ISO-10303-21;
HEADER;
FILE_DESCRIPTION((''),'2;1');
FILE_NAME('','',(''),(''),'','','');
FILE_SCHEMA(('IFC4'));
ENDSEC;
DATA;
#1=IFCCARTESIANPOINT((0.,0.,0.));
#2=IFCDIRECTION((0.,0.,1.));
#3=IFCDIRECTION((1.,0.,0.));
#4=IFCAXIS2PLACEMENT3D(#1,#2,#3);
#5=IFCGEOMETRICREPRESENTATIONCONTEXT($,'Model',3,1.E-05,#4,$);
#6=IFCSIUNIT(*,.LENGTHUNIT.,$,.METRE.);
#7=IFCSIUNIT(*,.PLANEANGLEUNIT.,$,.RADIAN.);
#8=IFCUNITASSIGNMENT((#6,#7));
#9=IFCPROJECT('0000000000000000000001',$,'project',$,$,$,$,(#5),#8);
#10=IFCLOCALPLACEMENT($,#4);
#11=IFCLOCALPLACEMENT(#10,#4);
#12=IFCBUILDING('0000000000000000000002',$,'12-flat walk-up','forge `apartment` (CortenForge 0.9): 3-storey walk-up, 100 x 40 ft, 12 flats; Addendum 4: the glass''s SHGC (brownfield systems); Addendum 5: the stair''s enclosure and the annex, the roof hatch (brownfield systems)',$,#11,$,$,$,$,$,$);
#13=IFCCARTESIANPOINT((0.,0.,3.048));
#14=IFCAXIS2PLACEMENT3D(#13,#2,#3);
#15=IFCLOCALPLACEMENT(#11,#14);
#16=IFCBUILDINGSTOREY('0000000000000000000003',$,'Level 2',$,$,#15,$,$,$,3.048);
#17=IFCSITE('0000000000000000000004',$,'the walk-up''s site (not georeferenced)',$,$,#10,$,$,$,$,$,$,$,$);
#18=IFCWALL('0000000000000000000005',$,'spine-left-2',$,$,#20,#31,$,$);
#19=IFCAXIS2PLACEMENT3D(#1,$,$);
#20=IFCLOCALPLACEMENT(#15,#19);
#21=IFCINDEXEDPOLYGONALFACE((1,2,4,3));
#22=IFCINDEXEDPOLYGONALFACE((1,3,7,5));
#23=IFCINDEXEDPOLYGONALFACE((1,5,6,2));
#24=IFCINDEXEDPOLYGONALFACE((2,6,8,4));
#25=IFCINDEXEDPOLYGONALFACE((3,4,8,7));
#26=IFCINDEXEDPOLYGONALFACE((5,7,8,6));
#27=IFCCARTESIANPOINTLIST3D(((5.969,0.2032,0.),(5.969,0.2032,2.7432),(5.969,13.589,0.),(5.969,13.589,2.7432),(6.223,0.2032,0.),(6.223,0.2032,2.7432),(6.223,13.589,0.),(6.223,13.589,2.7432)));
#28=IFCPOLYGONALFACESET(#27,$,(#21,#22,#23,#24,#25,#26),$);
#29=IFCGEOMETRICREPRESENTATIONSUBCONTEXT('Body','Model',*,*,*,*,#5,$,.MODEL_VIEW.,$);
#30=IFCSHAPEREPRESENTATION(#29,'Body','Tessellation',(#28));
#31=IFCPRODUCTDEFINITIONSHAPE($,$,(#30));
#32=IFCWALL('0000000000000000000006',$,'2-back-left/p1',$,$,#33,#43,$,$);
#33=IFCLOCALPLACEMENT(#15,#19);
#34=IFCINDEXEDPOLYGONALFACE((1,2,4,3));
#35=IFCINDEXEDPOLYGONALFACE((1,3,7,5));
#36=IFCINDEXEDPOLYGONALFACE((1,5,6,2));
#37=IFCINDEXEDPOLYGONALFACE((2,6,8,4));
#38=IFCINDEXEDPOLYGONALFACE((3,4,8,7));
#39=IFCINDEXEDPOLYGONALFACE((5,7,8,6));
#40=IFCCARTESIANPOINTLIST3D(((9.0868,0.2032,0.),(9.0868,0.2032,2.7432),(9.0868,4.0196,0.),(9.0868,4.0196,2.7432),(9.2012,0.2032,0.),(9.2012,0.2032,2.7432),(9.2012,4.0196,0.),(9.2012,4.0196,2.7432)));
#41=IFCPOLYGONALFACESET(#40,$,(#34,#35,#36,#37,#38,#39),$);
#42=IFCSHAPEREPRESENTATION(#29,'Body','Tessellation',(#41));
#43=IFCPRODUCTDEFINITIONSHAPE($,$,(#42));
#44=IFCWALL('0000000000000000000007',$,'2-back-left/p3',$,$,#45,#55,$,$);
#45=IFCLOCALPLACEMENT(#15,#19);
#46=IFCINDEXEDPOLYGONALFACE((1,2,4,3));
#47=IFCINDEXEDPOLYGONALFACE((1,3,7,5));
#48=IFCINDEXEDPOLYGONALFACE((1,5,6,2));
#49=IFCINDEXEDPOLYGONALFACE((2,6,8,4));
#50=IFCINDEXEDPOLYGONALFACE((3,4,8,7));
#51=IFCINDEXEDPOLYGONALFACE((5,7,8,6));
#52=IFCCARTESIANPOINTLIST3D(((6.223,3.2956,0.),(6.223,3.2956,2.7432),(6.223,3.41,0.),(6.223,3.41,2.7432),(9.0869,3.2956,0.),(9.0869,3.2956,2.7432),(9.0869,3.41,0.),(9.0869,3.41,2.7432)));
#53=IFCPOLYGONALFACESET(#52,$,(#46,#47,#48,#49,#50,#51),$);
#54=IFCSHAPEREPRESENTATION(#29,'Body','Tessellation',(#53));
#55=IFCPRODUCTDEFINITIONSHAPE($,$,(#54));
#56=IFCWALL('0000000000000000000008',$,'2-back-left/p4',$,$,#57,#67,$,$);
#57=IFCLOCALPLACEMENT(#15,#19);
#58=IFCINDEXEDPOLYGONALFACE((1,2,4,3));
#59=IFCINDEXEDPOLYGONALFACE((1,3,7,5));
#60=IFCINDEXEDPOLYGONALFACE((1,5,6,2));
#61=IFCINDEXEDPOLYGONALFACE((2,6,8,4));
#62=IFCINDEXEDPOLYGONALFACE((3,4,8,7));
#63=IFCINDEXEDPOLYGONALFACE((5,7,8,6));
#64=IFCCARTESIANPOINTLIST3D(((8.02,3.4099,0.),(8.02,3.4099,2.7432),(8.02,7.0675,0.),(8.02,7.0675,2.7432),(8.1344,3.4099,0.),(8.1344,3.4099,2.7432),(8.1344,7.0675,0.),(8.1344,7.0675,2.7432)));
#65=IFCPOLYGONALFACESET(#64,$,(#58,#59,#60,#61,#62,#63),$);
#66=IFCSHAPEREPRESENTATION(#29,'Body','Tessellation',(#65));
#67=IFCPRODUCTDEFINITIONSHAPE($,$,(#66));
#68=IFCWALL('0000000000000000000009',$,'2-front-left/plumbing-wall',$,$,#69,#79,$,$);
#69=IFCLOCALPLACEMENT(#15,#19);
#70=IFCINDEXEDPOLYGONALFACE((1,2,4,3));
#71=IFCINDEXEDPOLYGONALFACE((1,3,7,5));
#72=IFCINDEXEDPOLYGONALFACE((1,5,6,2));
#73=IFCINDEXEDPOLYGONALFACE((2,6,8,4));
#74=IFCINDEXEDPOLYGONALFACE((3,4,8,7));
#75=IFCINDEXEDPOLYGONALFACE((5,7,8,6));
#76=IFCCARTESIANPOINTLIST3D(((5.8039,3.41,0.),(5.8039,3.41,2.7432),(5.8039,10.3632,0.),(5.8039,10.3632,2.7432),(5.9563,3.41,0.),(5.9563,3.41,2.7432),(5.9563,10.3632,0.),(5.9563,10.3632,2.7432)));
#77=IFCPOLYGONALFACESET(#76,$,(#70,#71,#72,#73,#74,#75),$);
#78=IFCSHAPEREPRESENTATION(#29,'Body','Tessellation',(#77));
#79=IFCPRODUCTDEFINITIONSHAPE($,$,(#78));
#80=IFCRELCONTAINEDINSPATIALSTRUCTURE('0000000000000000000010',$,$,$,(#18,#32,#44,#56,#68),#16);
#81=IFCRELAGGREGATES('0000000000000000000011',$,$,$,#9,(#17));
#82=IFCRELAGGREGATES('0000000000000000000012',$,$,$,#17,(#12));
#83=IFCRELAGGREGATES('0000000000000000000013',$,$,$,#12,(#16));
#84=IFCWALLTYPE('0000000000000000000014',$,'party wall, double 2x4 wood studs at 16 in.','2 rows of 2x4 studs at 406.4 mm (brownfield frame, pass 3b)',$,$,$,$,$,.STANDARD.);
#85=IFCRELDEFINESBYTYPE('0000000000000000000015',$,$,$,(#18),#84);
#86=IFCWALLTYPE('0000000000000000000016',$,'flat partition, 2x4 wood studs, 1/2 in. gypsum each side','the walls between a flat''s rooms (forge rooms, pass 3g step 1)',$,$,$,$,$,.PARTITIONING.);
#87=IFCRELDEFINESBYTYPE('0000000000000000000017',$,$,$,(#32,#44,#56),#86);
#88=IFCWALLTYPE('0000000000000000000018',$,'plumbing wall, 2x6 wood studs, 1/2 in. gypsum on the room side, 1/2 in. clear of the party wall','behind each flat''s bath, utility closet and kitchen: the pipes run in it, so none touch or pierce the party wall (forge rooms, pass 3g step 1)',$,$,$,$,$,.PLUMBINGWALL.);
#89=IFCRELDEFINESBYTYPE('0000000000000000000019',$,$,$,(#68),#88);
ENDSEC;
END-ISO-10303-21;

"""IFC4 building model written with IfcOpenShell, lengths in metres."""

from ifc_helpers import new_model, si_unit, frame, frame_2d, origin, origin_with_axes, place, context, subcontext, project, spatial, rectangle, extrude, type_object, element, save


model = new_model("IFC4")

# Units and contexts
model_context = context("Model", 3, precision=1e-05, world=origin_with_axes())
body_context = subcontext(model_context, "Body", "Model", "MODEL_VIEW")
ifc_project = project(units=[si_unit("LENGTHUNIT", "METRE"), si_unit("PLANEANGLEUNIT", "RADIAN")], contexts=[model_context])

# Site, building, storey
site_placement = place(None, origin_with_axes())
site = spatial("IfcSite", under=ifc_project, at=site_placement, Name="the walk-up's site (not georeferenced)")
building_placement = place(site_placement, origin_with_axes())
building = spatial("IfcBuilding", under=site, at=building_placement, Name="12-flat walk-up", Description="forge `apartment` (CortenForge 0.9): 3-storey walk-up, 100 x 40 ft, 12 flats; Addendum 4: the glass's SHGC (brownfield systems); Addendum 5: the stair's enclosure and the annex, the roof hatch (brownfield systems)")
storey_placement = place(building_placement, frame((0.0, 0.0, 3.048), z_axis=(0.0, 0.0, 1.0), x_axis=(1.0, 0.0, 0.0)))
storey = spatial("IfcBuildingStorey", under=building, at=storey_placement, Name="Level 2", Elevation=3.048)

# Walls
wall_type_1 = type_object("IfcWallType", Name="party wall, double 2x4 wood studs at 16 in.", Description="2 rows of 2x4 studs at 406.4 mm (brownfield frame, pass 3b)", PredefinedType="STANDARD")
wall_1_placement = place(storey_placement, frame((5.969, 0.2032, 0.0), z_axis=(0.0, 0.0, 1.0), x_axis=(1.0, 0.0, 0.0)))
element("IfcWall", 1, at=wall_1_placement, inside=storey, type_object=wall_type_1, Name="spine-left-2", context=body_context, shape_type="SweptSolid", body=[
    extrude(rectangle(XDim=0.254, YDim=13.3858, at=frame_2d((0.127, 6.6929))), origin(), (0.0, 0.0, 1.0), 2.7432),
])
wall_type_2 = type_object("IfcWallType", Name="flat partition, 2x4 wood studs, 1/2 in. gypsum each side", Description="the walls between a flat's rooms (forge rooms, pass 3g step 1)", PredefinedType="PARTITIONING")
wall_2_placement = place(storey_placement, frame((9.0869, 0.2032, 0.0), z_axis=(0.0, 0.0, 1.0), x_axis=(1.0, 0.0, 0.0)))
element("IfcWall", 2, at=wall_2_placement, inside=storey, type_object=wall_type_2, Name="2-back-left/p1", context=body_context, shape_type="SweptSolid", body=[
    extrude(rectangle(XDim=0.1143, YDim=3.8163, at=frame_2d((0.0572, 1.9082))), origin(), (0.0, 0.0, 1.0), 2.7432),
])
wall_3_placement = place(storey_placement, frame((6.223, 3.2957, 0.0), z_axis=(0.0, 0.0, 1.0), x_axis=(1.0, 0.0, 0.0)))
element("IfcWall", 3, at=wall_3_placement, inside=storey, type_object=wall_type_2, Name="2-back-left/p3", context=body_context, shape_type="SweptSolid", body=[
    extrude(rectangle(XDim=2.8639, YDim=0.1143, at=frame_2d((1.4319, 0.0571))), origin(), (0.0, 0.0, 1.0), 2.7432),
])
wall_4_placement = place(storey_placement, frame((8.02, 3.4099, 0.0), z_axis=(0.0, 0.0, 1.0), x_axis=(1.0, 0.0, 0.0)))
element("IfcWall", 4, at=wall_4_placement, inside=storey, type_object=wall_type_2, Name="2-back-left/p4", context=body_context, shape_type="SweptSolid", body=[
    extrude(rectangle(XDim=0.1143, YDim=3.6576, at=frame_2d((0.0572, 1.8288))), origin(), (0.0, 0.0, 1.0), 2.7432),
])
wall_type_3 = type_object("IfcWallType", Name="plumbing wall, 2x6 wood studs, 1/2 in. gypsum on the room side, 1/2 in. clear of the party wall", Description="behind each flat's bath, utility closet and kitchen: the pipes run in it, so none touch or pierce the party wall (forge rooms, pass 3g step 1)", PredefinedType="PLUMBINGWALL")
wall_5_placement = place(storey_placement, frame((5.8039, 3.41, 0.0), z_axis=(0.0, 0.0, 1.0), x_axis=(1.0, 0.0, 0.0)))
element("IfcWall", 5, at=wall_5_placement, inside=storey, type_object=wall_type_3, Name="2-front-left/plumbing-wall", context=body_context, shape_type="SweptSolid", body=[
    extrude(rectangle(XDim=0.1524, YDim=6.9533, at=frame_2d((0.0762, 3.4766))), origin(), (0.0, 0.0, 1.0), 2.7432),
])

save(model, "model.ifc")
